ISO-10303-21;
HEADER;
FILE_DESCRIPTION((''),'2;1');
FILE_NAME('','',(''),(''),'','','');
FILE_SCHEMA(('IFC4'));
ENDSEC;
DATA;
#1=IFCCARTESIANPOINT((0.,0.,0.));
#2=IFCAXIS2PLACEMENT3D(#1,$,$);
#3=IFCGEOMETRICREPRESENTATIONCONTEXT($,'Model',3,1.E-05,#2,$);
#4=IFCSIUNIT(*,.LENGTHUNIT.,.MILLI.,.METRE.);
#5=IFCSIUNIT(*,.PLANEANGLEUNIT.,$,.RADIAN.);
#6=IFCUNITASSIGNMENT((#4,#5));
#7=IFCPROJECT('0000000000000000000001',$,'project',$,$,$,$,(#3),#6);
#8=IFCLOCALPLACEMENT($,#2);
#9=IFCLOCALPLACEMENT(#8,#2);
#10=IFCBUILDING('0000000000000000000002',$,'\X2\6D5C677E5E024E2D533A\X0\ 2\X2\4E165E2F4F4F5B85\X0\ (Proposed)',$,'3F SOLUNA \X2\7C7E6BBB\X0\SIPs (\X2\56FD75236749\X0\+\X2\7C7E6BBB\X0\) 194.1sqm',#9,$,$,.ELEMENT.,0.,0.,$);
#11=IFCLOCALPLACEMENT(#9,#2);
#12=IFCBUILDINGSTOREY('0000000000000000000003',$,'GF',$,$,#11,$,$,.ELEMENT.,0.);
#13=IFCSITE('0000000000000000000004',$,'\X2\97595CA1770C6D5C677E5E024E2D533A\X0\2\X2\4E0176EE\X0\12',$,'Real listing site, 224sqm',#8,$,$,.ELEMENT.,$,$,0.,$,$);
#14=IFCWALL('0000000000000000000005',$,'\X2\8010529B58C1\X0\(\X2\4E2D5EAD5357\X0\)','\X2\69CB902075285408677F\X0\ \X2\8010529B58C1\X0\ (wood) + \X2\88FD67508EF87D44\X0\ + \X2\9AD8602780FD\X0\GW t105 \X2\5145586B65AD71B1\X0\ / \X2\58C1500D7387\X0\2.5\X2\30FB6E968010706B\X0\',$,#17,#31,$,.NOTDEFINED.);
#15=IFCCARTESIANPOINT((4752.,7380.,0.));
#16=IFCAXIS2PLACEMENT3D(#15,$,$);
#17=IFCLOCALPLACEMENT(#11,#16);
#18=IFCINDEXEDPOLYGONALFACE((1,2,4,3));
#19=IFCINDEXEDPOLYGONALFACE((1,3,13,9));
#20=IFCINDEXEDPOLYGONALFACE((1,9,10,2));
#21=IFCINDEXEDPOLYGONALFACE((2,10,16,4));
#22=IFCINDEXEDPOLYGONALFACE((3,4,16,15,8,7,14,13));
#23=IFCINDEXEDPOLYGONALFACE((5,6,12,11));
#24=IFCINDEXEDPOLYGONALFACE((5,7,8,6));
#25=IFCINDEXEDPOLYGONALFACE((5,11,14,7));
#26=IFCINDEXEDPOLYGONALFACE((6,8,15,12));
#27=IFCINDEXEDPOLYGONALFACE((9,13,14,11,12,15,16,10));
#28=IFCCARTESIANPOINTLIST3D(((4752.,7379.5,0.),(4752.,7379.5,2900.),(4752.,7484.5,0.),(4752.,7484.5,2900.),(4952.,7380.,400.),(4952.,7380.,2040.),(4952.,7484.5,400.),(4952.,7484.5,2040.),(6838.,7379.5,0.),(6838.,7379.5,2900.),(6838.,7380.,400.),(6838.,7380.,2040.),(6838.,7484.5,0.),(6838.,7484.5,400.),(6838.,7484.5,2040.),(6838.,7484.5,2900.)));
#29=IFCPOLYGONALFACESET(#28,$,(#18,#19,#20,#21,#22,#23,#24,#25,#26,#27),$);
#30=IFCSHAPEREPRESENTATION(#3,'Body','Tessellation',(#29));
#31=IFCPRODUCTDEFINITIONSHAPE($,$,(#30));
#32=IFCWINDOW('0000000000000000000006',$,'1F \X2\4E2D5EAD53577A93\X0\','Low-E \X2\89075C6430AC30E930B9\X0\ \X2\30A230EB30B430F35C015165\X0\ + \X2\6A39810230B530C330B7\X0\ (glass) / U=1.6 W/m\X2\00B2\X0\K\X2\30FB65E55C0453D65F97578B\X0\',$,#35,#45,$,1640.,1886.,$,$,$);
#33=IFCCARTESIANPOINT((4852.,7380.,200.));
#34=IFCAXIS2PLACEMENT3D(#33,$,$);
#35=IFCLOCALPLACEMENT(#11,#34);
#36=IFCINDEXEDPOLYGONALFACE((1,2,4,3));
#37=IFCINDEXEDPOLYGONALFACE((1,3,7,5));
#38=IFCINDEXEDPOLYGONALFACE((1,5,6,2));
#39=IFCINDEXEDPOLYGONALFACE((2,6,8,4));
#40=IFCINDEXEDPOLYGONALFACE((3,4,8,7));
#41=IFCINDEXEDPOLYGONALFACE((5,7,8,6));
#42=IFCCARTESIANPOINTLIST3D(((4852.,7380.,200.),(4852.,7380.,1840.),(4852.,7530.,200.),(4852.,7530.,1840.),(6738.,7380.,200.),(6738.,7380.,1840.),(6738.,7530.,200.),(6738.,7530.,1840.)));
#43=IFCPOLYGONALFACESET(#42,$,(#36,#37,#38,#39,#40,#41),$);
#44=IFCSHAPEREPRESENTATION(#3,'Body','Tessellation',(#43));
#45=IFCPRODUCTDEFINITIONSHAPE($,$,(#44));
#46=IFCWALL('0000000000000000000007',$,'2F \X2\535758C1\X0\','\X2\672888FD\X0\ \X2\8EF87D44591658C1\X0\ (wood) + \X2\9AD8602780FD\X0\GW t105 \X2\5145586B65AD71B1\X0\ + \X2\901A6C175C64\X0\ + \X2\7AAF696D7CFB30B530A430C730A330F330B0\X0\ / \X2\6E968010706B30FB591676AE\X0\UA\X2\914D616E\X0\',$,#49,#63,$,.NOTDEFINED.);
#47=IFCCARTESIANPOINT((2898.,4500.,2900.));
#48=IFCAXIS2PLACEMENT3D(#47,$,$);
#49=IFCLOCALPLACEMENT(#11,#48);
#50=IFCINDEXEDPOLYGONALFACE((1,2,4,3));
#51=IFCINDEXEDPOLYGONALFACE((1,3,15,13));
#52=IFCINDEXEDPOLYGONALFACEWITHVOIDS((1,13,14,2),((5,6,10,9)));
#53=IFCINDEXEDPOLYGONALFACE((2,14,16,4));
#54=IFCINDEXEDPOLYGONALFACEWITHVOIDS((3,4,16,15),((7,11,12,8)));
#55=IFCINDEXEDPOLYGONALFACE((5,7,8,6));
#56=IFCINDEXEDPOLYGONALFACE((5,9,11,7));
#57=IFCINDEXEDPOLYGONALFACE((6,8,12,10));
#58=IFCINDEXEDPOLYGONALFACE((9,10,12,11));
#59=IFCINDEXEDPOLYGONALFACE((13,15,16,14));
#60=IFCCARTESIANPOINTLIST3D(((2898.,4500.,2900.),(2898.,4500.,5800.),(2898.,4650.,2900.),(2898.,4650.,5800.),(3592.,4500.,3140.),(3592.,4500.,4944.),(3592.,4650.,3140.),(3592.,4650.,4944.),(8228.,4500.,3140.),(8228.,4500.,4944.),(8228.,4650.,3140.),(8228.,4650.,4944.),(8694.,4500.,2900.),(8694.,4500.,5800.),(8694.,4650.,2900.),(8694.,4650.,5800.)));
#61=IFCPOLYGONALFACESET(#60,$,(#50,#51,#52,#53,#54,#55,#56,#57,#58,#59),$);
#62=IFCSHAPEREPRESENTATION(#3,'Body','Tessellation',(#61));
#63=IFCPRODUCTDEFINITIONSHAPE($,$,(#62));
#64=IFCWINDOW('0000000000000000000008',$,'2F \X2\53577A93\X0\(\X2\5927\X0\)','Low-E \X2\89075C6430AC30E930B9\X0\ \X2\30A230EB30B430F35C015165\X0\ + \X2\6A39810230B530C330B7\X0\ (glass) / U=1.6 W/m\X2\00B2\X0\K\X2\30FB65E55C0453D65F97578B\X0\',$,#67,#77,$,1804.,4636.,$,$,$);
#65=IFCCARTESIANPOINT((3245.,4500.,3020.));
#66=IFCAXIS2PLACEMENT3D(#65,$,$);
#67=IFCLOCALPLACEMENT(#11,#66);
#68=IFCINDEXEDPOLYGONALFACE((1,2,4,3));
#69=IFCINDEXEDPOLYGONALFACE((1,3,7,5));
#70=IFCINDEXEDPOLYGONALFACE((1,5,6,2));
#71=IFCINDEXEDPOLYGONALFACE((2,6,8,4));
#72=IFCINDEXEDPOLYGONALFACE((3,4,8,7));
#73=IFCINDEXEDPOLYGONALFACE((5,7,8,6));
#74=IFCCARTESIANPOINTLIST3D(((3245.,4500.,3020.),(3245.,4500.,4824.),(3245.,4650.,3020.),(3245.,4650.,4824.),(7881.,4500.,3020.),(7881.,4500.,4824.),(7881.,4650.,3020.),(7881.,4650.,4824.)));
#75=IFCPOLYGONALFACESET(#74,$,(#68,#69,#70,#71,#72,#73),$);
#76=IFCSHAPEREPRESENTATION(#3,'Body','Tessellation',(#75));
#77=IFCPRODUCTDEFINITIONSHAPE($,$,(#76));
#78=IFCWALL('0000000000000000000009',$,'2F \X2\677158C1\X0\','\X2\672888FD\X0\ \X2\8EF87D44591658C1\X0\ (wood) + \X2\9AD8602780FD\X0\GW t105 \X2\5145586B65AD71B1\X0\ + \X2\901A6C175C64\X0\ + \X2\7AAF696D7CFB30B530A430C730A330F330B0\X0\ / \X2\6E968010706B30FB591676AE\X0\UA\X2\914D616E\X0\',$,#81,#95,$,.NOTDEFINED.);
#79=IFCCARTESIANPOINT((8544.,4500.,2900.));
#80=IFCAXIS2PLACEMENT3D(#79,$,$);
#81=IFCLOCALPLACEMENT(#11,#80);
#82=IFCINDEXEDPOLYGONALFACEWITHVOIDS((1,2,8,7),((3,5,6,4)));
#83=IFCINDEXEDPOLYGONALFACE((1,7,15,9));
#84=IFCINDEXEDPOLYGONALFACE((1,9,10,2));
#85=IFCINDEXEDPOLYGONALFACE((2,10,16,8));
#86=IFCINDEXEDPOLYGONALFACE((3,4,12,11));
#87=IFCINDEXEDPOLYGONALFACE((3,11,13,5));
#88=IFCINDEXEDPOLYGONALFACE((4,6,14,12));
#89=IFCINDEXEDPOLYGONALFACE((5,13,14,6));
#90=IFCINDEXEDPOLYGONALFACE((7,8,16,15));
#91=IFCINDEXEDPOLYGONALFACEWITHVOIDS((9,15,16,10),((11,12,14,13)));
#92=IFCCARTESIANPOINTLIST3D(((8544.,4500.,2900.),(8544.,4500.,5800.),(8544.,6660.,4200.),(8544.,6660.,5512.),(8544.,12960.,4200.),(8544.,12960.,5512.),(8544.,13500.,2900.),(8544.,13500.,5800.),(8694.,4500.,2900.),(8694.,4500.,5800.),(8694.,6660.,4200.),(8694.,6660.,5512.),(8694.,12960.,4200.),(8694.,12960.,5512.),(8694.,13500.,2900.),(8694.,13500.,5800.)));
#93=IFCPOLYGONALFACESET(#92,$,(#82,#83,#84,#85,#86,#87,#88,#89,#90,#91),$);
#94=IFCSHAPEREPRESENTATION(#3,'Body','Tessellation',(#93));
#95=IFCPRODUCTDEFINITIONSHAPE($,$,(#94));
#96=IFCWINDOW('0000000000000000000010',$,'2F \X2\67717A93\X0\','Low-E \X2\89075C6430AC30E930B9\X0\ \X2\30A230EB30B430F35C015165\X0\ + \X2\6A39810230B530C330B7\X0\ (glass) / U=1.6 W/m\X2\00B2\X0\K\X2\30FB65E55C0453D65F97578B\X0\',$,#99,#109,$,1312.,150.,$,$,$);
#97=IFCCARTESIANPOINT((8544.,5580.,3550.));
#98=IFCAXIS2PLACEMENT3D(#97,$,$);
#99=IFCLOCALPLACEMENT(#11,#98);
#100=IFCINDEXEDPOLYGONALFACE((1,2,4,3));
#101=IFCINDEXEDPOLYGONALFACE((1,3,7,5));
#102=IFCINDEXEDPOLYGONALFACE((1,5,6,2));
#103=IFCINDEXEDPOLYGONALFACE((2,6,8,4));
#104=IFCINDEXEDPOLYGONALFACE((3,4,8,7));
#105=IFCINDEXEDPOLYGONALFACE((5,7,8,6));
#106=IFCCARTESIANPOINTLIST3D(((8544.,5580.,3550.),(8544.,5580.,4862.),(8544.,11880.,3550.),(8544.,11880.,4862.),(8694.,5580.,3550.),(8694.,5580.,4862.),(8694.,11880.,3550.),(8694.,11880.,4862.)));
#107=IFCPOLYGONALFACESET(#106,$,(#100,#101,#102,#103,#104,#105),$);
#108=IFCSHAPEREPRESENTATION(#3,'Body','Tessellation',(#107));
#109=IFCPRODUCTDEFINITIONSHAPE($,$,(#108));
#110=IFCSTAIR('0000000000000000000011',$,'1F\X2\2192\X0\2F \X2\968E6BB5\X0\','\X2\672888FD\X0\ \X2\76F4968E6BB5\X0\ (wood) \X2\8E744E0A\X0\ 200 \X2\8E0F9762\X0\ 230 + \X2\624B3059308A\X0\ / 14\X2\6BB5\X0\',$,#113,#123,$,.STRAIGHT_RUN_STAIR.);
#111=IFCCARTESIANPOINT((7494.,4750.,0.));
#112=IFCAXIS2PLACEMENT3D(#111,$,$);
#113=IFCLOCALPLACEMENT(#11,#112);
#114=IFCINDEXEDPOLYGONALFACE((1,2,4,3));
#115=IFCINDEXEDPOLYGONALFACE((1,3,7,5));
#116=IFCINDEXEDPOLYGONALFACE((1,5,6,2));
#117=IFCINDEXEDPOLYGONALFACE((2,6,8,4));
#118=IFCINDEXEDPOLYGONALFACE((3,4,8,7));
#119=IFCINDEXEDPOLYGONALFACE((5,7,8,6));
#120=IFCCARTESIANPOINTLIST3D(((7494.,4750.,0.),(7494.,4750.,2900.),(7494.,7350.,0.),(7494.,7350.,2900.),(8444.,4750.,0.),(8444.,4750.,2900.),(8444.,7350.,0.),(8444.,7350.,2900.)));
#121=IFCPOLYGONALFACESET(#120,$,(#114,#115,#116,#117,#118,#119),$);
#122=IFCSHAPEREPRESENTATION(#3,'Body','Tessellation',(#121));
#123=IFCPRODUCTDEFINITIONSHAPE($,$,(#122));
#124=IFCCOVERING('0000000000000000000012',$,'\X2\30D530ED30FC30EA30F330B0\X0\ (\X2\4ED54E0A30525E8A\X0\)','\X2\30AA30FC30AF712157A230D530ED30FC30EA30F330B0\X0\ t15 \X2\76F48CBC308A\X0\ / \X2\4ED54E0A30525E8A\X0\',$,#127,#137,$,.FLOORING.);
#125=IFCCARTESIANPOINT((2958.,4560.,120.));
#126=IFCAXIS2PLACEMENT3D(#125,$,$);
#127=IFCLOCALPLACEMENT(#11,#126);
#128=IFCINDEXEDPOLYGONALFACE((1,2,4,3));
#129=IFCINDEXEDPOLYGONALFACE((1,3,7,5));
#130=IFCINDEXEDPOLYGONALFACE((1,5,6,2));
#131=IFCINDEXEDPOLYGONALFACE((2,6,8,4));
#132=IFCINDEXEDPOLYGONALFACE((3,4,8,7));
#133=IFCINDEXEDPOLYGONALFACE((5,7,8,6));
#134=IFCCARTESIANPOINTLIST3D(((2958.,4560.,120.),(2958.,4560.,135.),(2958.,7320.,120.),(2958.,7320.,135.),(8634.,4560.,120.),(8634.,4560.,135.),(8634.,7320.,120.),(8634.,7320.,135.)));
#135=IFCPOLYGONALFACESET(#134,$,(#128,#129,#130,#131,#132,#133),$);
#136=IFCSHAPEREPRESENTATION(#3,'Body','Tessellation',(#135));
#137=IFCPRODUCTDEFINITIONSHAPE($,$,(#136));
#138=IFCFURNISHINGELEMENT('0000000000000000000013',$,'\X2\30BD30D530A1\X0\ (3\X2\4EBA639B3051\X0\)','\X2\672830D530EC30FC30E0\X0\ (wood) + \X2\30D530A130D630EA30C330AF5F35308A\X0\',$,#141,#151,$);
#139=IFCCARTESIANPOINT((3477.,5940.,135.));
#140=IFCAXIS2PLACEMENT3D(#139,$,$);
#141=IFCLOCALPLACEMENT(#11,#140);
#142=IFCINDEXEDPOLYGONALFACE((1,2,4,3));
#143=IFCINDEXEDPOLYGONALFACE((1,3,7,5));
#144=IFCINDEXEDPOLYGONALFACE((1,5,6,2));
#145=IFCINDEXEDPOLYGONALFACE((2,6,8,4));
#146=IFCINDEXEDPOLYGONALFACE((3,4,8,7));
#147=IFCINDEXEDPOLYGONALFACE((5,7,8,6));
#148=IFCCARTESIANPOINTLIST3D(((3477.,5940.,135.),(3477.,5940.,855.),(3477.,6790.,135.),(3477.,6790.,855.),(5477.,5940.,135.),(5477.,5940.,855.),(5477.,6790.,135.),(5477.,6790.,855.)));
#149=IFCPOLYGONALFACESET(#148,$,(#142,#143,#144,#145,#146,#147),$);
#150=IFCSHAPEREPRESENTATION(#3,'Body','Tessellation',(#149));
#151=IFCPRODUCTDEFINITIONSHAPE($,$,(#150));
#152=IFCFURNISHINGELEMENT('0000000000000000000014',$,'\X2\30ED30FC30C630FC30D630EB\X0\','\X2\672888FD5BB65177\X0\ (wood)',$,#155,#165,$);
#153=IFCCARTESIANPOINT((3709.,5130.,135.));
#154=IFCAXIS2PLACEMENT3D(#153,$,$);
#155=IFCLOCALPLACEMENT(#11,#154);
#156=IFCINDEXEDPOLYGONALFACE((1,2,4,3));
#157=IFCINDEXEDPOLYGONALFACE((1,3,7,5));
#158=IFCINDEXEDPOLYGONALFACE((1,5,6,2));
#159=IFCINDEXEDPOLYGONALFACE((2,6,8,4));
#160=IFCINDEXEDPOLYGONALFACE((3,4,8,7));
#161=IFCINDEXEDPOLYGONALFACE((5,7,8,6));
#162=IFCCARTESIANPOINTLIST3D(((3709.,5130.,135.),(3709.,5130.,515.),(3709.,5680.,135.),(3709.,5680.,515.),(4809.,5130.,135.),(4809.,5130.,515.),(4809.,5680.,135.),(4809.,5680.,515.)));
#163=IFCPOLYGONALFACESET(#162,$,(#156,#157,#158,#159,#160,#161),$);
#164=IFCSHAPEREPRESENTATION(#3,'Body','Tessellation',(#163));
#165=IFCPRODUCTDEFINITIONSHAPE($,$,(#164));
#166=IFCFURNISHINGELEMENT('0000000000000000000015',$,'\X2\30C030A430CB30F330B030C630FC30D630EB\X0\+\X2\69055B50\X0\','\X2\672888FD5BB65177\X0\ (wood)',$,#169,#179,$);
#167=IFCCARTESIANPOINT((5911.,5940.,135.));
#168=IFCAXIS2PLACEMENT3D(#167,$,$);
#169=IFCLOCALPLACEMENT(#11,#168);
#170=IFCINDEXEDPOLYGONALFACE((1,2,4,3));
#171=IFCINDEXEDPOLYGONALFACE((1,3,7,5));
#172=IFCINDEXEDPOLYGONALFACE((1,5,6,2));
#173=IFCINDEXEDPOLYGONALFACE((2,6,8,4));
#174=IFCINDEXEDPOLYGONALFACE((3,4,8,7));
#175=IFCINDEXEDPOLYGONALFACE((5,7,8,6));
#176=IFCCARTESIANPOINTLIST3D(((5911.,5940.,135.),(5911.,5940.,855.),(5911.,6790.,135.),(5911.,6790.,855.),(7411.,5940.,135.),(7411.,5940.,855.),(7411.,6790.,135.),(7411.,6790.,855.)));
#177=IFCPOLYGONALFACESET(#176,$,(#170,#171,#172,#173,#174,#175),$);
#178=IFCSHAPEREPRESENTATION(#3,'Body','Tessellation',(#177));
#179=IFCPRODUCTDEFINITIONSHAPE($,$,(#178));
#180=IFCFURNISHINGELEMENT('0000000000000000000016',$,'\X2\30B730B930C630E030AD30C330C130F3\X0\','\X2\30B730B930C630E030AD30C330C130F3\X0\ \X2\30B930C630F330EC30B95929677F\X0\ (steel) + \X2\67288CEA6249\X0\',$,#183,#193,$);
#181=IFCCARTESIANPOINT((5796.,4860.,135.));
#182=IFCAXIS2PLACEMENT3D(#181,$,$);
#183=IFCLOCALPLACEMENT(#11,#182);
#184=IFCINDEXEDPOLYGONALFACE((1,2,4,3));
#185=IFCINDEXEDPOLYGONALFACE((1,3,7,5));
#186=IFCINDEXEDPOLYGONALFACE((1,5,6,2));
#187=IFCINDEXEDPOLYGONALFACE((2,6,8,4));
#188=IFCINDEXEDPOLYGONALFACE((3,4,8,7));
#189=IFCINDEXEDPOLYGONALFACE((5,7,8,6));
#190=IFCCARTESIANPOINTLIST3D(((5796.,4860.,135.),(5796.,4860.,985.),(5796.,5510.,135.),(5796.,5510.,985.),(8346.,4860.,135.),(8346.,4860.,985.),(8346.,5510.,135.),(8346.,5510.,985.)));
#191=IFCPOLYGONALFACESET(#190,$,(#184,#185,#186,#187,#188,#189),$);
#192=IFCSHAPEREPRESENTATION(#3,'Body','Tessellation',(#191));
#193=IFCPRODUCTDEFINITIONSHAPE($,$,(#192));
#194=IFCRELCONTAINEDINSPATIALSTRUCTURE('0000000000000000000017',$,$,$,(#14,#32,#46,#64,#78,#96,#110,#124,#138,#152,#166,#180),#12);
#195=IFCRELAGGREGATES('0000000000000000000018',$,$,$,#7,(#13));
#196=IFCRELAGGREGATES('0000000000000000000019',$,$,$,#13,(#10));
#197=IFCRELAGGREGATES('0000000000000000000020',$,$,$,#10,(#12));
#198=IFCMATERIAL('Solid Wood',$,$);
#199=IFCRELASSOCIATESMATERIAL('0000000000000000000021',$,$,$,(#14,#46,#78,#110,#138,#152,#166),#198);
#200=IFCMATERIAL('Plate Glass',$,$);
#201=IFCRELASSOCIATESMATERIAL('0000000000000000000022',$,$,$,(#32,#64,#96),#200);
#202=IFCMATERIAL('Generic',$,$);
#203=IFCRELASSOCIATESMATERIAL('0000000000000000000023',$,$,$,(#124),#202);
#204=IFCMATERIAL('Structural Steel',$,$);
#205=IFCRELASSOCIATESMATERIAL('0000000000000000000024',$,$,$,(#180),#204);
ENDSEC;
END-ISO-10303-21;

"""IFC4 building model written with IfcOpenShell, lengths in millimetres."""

from ifc_helpers import new_model, si_unit, frame, frame_2d, origin, place, context, project, spatial, rectangle, extrude, material, element, fill, save


model = new_model("IFC4")

# Units and contexts
model_context = context("Model", 3, precision=1e-05, world=origin())
ifc_project = project(units=[si_unit("LENGTHUNIT", "METRE", prefix="MILLI"), si_unit("PLANEANGLEUNIT", "RADIAN")], contexts=[model_context])

# Site, building, storey
site_placement = place(None, origin())
site = spatial("IfcSite", under=ifc_project, at=site_placement, Name="静岡県浜松市中区2丁目12", ObjectType="Real listing site, 224sqm", CompositionType="ELEMENT", RefElevation=0.0)
building_placement = place(site_placement, origin())
building = spatial("IfcBuilding", under=site, at=building_placement, Name="浜松市中区 2世帯住宅 (Proposed)", ObjectType="3F SOLUNA 籾殻SIPs (国産杉+籾殻) 194.1sqm", CompositionType="ELEMENT", ElevationOfRefHeight=0.0, ElevationOfTerrain=0.0)
storey_placement = place(building_placement, origin())
storey = spatial("IfcBuildingStorey", under=building, at=storey_placement, Name="GF", CompositionType="ELEMENT", Elevation=0.0)

# Shared definitions
ifc_material_1 = material(Name="Solid Wood")

# Shared definitions
ifc_material_2 = material(Name="Plate Glass")

# Wall, opening, window
wall_1_placement = place(storey_placement, frame((4752.0, 7380.0, 0.0)))
wall_1 = element("IfcWall", 1, at=wall_1_placement, inside=storey, material=ifc_material_1, Name="耐力壁(中庭南)", Description="構造用合板 耐力壁 (wood) + 製材軸組 + 高性能GW t105 充填断熱 / 壁倍率2.5・準耐火", PredefinedType="NOTDEFINED", context=model_context, shape_type="SweptSolid", body=[
    extrude(rectangle(XDim=2086.0, YDim=105.0, at=frame_2d((1043.0, 52.0))), frame((4752.0, 7380.0, 0.0)), (0.0, 0.0, 1.0), 2900.0),
])
opening_1_placement = place(storey_placement, frame((4852.0, 7380.0, 200.0)))
opening_1 = element("IfcOpeningElement", 2, at=opening_1_placement, cuts=wall_1, PredefinedType="NOTDEFINED", context=model_context, shape_type="SweptSolid", body=[
    extrude(rectangle(XDim=1886.0, YDim=150.0, at=frame_2d((943.0, 75.0))), frame((4852.0, 7380.0, 200.0)), (0.0, 0.0, 1.0), 1640.0),
])
window_1_placement = place(storey_placement, frame((4852.0, 7380.0, 200.0)))
window_1 = element("IfcWindow", 3, at=window_1_placement, inside=storey, material=ifc_material_2, Name="1F 中庭南窓", Description="Low-E 複層ガラス アルゴン封入 + 樹脂サッシ (glass) / U=1.6 W/m²K・日射取得型", OverallHeight=1640.0, OverallWidth=1886.0, context=model_context, shape_type="SweptSolid", body=[
    extrude(rectangle(XDim=1886.0, YDim=150.0, at=frame_2d((943.0, 75.0))), frame((4852.0, 7380.0, 200.0)), (0.0, 0.0, 1.0), 1640.0),
])
fill(opening_1, window_1)

# Walls, openings, windows
wall_2_placement = place(storey_placement, frame((2898.0, 4500.0, 2900.0)))
wall_2 = element("IfcWall", 4, at=wall_2_placement, inside=storey, material=ifc_material_1, Name="2F 南壁", Description="木製 軸組外壁 (wood) + 高性能GW t105 充填断熱 + 通気層 + 窯業系サイディング / 準耐火・外皮UA配慮", PredefinedType="NOTDEFINED", context=model_context, shape_type="SweptSolid", body=[
    extrude(rectangle(XDim=5796.0, YDim=150.0, at=frame_2d((2898.0, 75.0))), frame((2898.0, 4500.0, 2900.0)), (0.0, 0.0, 1.0), 2900.0),
])
opening_2_placement = place(storey_placement, frame((3245.0, 4500.0, 3020.0)))
opening_2 = element("IfcOpeningElement", 5, at=opening_2_placement, cuts=wall_2, PredefinedType="NOTDEFINED", context=model_context, shape_type="SweptSolid", body=[
    extrude(rectangle(XDim=4636.0, YDim=150.0, at=frame_2d((2318.0, 75.0))), frame((3245.0, 4500.0, 3020.0)), (0.0, 0.0, 1.0), 1804.0),
])
window_2_placement = place(storey_placement, frame((3245.0, 4500.0, 3020.0)))
window_2 = element("IfcWindow", 6, at=window_2_placement, inside=storey, material=ifc_material_2, Name="2F 南窓(大)", Description="Low-E 複層ガラス アルゴン封入 + 樹脂サッシ (glass) / U=1.6 W/m²K・日射取得型", OverallHeight=1804.0, OverallWidth=4636.0, context=model_context, shape_type="SweptSolid", body=[
    extrude(rectangle(XDim=4636.0, YDim=150.0, at=frame_2d((2318.0, 75.0))), frame((3245.0, 4500.0, 3020.0)), (0.0, 0.0, 1.0), 1804.0),
])
fill(opening_2, window_2)
wall_3_placement = place(storey_placement, frame((8544.0, 4500.0, 2900.0)))
wall_3 = element("IfcWall", 7, at=wall_3_placement, inside=storey, material=ifc_material_1, Name="2F 東壁", Description="木製 軸組外壁 (wood) + 高性能GW t105 充填断熱 + 通気層 + 窯業系サイディング / 準耐火・外皮UA配慮", PredefinedType="NOTDEFINED", context=model_context, shape_type="SweptSolid", body=[
    extrude(rectangle(XDim=150.0, YDim=9000.0, at=frame_2d((75.0, 4500.0))), frame((8544.0, 4500.0, 2900.0)), (0.0, 0.0, 1.0), 2900.0),
])
opening_3_placement = place(storey_placement, frame((8544.0, 5580.0, 3550.0)))
opening_3 = element("IfcOpeningElement", 8, at=opening_3_placement, cuts=wall_3, PredefinedType="NOTDEFINED", context=model_context, shape_type="SweptSolid", body=[
    extrude(rectangle(XDim=150.0, YDim=6300.0, at=frame_2d((75.0, 3150.0))), frame((8544.0, 5580.0, 3550.0)), (0.0, 0.0, 1.0), 1312.0),
])
window_3_placement = place(storey_placement, frame((8544.0, 5580.0, 3550.0)))
window_3 = element("IfcWindow", 9, at=window_3_placement, inside=storey, material=ifc_material_2, Name="2F 東窓", Description="Low-E 複層ガラス アルゴン封入 + 樹脂サッシ (glass) / U=1.6 W/m²K・日射取得型", OverallHeight=1312.0, OverallWidth=150.0, context=model_context, shape_type="SweptSolid", body=[
    extrude(rectangle(XDim=150.0, YDim=6300.0, at=frame_2d((75.0, 3150.0))), frame((8544.0, 5580.0, 3550.0)), (0.0, 0.0, 1.0), 1312.0),
])
fill(opening_3, window_3)

# Stair
stair_placement = place(storey_placement, frame((7494.0, 4750.0, 0.0)))
element("IfcStair", 10, at=stair_placement, inside=storey, material=ifc_material_1, Name="1F→2F 階段", Description="木製 直階段 (wood) 蹴上 200 踏面 230 + 手すり / 14段", PredefinedType="STRAIGHT_RUN_STAIR", context=model_context, shape_type="SweptSolid", body=[
    extrude(rectangle(XDim=950.0, YDim=2600.0, at=frame_2d((475.0, 1300.0))), frame((7494.0, 4750.0, 0.0)), (0.0, 0.0, 1.0), 2900.0),
])

# Covering
ifc_material_3 = material(Name="Generic")
covering_placement = place(storey_placement, frame((2958.0, 4560.0, 120.0)))
element("IfcCovering", 11, at=covering_placement, inside=storey, material=ifc_material_3, Name="フローリング (仕上げ床)", Description="オーク無垢フローリング t15 直貼り / 仕上げ床", PredefinedType="FLOORING", context=model_context, shape_type="SweptSolid", body=[
    extrude(rectangle(XDim=5676.0, YDim=2760.0, at=frame_2d((2838.0, 1380.0))), frame((2958.0, 4560.0, 120.0)), (0.0, 0.0, 1.0), 15.0),
])

# Furnishing elements
furnishing_1_placement = place(storey_placement, frame((3477.0, 5940.0, 135.0)))
element("IfcFurnishingElement", 12, at=furnishing_1_placement, inside=storey, material=ifc_material_1, Name="ソファ (3人掛け)", Description="木フレーム (wood) + ファブリック張り", context=model_context, shape_type="SweptSolid", body=[
    extrude(rectangle(XDim=2000.0, YDim=850.0, at=frame_2d((1000.0, 425.0))), frame((3477.0, 5940.0, 135.0)), (0.0, 0.0, 1.0), 720.0),
])
furnishing_2_placement = place(storey_placement, frame((3709.0, 5130.0, 135.0)))
element("IfcFurnishingElement", 13, at=furnishing_2_placement, inside=storey, material=ifc_material_1, Name="ローテーブル", Description="木製家具 (wood)", context=model_context, shape_type="SweptSolid", body=[
    extrude(rectangle(XDim=1100.0, YDim=550.0, at=frame_2d((550.0, 275.0))), frame((3709.0, 5130.0, 135.0)), (0.0, 0.0, 1.0), 380.0),
])
furnishing_3_placement = place(storey_placement, frame((5911.0, 5940.0, 135.0)))
element("IfcFurnishingElement", 14, at=furnishing_3_placement, inside=storey, material=ifc_material_1, Name="ダイニングテーブル+椅子", Description="木製家具 (wood)", context=model_context, shape_type="SweptSolid", body=[
    extrude(rectangle(XDim=1500.0, YDim=850.0, at=frame_2d((750.0, 425.0))), frame((5911.0, 5940.0, 135.0)), (0.0, 0.0, 1.0), 720.0),
])
ifc_material_4 = material(Name="Structural Steel")
furnishing_4_placement = place(storey_placement, frame((5796.0, 4860.0, 135.0)))
element("IfcFurnishingElement", 15, at=furnishing_4_placement, inside=storey, material=ifc_material_4, Name="システムキッチン", Description="システムキッチン ステンレス天板 (steel) + 木質扉", context=model_context, shape_type="SweptSolid", body=[
    extrude(rectangle(XDim=2550.0, YDim=650.0, at=frame_2d((1275.0, 325.0))), frame((5796.0, 4860.0, 135.0)), (0.0, 0.0, 1.0), 850.0),
])

save(model, "model.ifc")
